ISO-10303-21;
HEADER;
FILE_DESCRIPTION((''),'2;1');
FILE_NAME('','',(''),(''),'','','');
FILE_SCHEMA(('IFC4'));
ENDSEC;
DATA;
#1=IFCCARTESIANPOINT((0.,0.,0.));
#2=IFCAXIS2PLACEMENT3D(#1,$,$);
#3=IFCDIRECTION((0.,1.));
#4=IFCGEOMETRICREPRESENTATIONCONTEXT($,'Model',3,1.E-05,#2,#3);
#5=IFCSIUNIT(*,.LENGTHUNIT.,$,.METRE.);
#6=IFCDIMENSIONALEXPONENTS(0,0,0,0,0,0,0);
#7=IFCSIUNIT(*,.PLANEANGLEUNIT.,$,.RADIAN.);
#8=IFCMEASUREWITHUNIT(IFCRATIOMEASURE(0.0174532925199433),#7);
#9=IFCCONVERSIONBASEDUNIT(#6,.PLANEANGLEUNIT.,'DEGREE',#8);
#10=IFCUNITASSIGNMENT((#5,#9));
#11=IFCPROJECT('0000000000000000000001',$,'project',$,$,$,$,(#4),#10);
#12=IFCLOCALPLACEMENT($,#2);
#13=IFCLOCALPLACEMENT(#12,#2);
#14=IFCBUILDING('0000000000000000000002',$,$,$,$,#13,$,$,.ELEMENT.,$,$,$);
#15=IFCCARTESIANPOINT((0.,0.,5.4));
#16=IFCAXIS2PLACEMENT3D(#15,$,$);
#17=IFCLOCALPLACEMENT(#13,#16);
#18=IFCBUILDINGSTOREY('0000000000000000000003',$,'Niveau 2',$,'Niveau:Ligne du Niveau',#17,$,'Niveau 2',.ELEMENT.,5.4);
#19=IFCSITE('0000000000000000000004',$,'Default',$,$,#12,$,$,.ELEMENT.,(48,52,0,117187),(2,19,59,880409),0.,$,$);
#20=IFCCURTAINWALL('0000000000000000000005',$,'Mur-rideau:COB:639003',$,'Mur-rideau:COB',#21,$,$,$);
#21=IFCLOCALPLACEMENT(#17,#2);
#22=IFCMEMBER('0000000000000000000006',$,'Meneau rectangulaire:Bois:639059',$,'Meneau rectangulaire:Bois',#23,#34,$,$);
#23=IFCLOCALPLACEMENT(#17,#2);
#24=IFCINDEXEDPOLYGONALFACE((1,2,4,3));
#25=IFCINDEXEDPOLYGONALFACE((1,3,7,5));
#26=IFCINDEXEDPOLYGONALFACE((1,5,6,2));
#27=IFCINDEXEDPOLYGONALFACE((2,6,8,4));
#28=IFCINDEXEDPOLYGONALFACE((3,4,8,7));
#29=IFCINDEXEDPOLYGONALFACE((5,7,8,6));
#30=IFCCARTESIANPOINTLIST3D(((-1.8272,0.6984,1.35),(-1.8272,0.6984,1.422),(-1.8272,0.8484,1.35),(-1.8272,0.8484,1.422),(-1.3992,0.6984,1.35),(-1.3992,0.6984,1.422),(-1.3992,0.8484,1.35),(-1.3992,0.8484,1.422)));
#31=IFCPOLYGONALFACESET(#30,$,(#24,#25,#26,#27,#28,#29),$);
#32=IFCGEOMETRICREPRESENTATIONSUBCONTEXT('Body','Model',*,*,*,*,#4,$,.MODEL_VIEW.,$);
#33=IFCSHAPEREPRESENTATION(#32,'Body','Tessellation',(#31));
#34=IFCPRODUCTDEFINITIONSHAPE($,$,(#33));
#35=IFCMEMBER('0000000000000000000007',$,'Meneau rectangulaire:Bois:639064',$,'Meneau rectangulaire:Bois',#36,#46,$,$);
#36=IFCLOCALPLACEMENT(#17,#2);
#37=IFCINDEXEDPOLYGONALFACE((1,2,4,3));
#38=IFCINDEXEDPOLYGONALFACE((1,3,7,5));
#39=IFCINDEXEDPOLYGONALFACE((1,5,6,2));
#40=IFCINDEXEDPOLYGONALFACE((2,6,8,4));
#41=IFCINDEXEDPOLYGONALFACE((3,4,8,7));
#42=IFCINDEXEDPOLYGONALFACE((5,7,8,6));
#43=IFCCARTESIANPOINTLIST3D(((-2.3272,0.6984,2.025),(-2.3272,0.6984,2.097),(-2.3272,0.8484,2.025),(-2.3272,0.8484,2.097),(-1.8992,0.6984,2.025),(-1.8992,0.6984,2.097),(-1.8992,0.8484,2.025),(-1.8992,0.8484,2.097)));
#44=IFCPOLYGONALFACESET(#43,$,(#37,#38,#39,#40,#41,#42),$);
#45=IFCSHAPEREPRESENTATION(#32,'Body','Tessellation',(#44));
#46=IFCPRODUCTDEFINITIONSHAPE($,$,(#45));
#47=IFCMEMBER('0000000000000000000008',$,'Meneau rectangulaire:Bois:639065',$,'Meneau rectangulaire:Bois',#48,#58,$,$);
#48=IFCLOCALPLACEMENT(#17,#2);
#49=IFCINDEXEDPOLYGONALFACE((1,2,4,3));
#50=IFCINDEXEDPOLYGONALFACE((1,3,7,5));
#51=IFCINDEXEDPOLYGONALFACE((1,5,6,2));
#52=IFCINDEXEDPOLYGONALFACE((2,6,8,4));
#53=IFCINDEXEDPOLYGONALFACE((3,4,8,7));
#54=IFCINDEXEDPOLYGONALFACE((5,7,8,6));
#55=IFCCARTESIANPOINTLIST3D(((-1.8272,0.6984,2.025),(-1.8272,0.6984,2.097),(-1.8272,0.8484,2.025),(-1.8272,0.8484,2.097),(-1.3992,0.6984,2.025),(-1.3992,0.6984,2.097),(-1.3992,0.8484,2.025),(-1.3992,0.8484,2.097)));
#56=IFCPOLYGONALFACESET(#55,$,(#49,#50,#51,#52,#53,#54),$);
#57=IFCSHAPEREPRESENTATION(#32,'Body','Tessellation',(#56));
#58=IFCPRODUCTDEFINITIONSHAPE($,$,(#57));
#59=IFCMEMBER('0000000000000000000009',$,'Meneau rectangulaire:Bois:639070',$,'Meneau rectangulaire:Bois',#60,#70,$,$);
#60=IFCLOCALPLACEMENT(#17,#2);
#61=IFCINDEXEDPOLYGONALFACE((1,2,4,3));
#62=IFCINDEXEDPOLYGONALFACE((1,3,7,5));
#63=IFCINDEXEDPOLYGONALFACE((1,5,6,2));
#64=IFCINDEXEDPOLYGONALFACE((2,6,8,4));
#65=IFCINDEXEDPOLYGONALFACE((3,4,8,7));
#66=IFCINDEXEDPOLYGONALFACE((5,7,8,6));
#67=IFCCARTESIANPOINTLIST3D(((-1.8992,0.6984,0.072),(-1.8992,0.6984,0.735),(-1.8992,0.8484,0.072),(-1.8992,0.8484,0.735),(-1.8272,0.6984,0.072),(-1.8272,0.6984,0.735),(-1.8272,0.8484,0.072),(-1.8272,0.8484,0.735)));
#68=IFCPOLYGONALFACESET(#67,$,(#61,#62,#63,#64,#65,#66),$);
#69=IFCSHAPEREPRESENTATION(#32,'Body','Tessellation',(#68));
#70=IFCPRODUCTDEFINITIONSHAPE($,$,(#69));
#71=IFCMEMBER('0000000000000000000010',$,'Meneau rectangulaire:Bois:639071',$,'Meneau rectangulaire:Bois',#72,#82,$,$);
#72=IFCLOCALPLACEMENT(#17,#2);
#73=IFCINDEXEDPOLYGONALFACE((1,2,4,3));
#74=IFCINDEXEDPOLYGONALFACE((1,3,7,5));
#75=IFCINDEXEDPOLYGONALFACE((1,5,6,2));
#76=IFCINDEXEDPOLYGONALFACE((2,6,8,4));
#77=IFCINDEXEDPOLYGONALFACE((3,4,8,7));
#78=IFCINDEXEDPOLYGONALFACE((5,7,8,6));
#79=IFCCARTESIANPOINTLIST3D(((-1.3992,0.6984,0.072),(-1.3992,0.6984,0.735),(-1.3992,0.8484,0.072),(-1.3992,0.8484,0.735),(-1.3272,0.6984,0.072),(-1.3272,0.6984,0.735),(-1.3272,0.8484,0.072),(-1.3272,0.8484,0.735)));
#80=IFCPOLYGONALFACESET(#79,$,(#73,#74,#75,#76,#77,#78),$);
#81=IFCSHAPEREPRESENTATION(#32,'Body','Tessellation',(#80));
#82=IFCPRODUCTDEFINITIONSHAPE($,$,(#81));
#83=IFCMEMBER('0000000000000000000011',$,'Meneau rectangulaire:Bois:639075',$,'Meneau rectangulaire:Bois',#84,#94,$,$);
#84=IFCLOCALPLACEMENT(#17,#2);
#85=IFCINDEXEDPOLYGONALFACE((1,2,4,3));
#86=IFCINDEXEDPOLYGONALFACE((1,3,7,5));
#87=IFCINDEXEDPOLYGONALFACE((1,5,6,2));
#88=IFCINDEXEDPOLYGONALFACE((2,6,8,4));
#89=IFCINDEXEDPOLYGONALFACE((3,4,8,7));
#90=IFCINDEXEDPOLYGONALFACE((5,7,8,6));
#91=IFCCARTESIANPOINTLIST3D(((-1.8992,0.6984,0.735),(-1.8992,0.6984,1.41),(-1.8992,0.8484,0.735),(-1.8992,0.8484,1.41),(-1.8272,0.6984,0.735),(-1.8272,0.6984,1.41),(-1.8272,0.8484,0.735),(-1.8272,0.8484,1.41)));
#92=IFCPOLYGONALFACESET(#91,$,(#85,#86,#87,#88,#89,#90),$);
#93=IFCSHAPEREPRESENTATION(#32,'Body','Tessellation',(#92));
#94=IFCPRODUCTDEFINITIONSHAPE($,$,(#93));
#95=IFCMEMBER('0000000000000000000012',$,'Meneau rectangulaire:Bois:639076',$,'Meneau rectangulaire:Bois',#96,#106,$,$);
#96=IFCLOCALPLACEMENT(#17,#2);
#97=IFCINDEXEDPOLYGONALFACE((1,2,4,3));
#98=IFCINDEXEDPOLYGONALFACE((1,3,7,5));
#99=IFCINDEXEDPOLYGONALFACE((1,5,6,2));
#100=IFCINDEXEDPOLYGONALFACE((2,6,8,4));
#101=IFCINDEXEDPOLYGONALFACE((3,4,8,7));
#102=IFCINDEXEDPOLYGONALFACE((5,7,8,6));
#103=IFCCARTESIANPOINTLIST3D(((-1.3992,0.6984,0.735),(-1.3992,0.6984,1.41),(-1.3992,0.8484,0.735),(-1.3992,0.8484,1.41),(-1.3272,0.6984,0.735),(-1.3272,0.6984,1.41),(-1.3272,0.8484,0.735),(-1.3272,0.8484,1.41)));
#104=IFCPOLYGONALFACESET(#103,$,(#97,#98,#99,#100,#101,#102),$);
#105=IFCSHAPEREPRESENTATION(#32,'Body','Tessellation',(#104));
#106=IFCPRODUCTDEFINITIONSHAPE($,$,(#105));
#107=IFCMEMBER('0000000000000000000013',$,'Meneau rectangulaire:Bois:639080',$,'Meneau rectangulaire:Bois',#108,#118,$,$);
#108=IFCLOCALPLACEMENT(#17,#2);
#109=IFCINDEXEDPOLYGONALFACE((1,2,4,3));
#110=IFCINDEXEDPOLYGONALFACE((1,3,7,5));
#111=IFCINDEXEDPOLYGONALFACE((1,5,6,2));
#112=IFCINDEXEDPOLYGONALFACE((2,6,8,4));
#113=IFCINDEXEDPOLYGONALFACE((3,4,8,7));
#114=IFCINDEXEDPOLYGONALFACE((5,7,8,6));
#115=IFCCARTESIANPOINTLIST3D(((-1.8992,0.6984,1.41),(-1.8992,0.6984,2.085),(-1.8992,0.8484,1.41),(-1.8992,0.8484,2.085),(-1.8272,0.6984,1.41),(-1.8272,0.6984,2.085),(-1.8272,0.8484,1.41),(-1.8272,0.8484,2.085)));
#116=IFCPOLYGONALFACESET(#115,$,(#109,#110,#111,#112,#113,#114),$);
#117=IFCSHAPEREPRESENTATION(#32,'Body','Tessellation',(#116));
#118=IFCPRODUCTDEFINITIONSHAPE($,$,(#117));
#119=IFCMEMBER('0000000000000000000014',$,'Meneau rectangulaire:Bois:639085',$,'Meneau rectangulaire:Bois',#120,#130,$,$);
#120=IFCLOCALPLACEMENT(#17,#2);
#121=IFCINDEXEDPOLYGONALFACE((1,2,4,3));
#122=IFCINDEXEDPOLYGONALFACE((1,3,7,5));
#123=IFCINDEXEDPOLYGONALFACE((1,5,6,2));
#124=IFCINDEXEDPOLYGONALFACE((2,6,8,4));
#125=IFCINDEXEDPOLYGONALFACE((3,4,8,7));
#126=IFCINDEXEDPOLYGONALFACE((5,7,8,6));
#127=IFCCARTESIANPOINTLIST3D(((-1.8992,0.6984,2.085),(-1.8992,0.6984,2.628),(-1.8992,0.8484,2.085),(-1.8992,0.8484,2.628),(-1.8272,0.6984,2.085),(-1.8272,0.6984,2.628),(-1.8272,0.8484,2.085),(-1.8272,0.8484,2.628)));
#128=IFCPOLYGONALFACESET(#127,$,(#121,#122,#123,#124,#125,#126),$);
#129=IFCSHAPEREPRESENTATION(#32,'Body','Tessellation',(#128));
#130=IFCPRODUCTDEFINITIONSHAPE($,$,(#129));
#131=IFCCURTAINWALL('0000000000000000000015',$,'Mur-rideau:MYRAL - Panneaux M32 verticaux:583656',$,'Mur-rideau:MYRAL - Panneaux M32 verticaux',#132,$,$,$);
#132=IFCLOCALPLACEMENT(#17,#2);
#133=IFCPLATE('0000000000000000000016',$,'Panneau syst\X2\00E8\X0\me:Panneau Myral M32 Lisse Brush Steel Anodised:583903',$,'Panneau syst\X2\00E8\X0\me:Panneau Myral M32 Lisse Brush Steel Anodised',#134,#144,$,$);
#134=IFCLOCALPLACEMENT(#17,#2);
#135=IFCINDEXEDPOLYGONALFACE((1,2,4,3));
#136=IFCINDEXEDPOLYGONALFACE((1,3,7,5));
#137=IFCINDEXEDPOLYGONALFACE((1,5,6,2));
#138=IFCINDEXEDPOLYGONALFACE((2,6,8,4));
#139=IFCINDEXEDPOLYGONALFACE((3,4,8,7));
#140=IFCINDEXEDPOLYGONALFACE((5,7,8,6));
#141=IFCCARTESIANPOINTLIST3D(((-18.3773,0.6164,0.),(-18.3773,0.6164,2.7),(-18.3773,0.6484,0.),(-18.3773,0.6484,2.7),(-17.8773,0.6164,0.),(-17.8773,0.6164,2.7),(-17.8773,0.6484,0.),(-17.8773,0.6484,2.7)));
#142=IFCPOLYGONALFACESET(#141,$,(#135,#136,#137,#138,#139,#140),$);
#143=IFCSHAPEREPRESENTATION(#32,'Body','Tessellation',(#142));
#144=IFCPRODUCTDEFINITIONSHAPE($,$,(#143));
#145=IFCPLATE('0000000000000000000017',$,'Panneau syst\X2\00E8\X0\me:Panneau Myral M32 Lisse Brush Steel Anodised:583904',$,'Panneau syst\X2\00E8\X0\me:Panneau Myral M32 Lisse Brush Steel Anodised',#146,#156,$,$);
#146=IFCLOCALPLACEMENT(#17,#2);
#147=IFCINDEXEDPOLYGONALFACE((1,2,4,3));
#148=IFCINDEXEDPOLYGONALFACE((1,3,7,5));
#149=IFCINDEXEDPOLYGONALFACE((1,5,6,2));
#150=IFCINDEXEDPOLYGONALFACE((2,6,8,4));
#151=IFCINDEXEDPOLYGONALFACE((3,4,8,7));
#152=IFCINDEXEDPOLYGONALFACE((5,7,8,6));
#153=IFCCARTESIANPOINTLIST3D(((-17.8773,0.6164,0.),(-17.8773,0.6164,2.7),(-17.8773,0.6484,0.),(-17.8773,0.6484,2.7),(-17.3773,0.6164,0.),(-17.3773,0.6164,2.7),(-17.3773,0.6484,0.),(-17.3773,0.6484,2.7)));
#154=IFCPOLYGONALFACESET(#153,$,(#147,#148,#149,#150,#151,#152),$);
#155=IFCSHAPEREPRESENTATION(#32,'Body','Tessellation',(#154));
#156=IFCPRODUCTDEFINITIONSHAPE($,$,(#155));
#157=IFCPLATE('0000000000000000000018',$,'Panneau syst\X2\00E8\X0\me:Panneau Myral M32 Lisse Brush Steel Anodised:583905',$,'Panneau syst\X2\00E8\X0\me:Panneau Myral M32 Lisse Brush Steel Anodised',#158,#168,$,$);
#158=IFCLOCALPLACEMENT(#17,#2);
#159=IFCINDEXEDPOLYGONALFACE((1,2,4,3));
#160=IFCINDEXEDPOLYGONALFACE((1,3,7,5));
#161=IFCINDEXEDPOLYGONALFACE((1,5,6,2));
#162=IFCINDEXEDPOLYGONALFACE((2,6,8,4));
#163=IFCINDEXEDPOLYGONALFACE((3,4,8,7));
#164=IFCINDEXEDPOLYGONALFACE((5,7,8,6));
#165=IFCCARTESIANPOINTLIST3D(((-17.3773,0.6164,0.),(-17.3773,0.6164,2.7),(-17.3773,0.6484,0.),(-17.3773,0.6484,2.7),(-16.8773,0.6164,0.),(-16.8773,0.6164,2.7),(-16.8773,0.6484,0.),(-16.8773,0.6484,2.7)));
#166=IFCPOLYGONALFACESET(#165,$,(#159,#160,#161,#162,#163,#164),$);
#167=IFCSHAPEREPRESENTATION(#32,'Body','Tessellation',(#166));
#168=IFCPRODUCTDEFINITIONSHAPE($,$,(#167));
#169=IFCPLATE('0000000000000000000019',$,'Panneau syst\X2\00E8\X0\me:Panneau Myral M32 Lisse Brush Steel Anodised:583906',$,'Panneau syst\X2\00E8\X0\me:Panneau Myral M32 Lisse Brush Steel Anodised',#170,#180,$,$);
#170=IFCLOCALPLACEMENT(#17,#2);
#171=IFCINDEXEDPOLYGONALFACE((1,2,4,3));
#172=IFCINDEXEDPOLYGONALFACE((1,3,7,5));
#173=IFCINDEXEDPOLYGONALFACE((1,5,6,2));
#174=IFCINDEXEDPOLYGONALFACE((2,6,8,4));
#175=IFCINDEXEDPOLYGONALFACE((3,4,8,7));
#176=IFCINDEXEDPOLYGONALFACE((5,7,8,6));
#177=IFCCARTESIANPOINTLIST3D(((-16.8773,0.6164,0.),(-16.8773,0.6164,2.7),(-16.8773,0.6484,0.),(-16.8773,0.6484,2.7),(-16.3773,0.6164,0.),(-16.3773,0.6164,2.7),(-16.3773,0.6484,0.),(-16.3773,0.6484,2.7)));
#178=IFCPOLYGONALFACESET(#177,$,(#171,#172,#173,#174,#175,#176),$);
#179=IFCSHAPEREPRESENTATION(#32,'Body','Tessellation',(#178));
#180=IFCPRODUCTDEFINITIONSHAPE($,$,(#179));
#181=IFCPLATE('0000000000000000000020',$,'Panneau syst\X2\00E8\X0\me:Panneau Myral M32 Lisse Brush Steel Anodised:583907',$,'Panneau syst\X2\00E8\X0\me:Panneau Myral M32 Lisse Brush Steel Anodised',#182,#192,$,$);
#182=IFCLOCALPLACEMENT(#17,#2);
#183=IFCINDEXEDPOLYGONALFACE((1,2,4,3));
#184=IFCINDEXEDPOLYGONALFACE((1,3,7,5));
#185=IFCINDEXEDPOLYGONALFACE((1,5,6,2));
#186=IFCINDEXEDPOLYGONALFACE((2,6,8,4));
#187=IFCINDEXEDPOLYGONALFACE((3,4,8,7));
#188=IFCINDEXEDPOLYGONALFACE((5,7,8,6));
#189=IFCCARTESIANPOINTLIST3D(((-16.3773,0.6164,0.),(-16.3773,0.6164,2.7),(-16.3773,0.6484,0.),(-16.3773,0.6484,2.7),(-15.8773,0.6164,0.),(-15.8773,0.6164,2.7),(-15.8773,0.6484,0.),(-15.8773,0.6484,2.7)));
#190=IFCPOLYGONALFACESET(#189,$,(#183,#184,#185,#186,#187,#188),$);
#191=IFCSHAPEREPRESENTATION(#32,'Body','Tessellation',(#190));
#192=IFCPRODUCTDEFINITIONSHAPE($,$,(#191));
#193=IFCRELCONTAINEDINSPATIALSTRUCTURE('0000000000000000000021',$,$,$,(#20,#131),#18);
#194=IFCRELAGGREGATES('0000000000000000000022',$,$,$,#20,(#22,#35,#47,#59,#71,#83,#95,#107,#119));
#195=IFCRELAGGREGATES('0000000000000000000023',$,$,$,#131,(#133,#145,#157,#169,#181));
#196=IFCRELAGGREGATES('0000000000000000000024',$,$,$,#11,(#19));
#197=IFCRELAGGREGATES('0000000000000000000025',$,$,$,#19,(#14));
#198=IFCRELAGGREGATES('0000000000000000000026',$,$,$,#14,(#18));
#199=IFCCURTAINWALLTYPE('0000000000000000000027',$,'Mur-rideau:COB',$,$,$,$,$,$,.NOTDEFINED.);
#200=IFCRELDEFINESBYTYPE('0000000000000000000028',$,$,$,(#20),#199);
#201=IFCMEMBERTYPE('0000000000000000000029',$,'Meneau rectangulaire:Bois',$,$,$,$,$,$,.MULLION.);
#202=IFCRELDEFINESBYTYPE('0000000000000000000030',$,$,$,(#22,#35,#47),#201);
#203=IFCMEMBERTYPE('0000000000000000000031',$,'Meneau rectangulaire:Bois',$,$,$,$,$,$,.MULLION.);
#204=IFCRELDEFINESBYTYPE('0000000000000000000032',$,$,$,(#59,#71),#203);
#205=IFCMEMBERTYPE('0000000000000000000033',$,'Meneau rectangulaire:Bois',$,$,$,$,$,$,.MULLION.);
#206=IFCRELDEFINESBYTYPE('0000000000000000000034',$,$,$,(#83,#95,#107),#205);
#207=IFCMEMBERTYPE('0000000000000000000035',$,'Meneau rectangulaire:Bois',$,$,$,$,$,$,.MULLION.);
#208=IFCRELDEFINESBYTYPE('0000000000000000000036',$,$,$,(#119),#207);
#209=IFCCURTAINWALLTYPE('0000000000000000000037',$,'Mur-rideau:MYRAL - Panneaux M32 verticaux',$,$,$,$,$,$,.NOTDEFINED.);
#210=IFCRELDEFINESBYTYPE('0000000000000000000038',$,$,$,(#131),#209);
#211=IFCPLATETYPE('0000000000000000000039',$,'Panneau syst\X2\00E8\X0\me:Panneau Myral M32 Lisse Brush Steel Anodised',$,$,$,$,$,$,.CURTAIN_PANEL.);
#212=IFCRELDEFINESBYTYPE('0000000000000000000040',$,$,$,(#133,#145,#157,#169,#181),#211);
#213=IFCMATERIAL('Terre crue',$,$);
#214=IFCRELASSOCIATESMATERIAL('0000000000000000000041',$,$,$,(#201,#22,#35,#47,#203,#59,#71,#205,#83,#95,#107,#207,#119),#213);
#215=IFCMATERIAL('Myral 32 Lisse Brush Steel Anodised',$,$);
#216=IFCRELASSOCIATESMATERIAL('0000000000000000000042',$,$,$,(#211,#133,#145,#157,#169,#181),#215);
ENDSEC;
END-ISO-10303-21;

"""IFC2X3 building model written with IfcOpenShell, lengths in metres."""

from ifc_helpers import new_model, entity, si_unit, converted_unit, direction, frame, origin, origin_2d_with_axis, place, context, subcontext, project, spatial, rectangle, extrude, source, transform, mapped, material, type_object, type_shapes, element, aggregate, save


model = new_model("IFC2X3")

# Units and contexts
model_context = context("Model", 3, precision=1e-05, world=origin(), true_north=direction((0.0, 1.0)))
body_context = subcontext(model_context, "Body", "Model", "MODEL_VIEW")
ifc_project = project(units=[si_unit("LENGTHUNIT", "METRE"), converted_unit("PLANEANGLEUNIT", "DEGREE", entity("IfcRatioMeasure", 0.0174532925199433), si_unit("PLANEANGLEUNIT", "RADIAN"), dimensions=[0, 0, 0, 0, 0, 0, 0])], contexts=[model_context])

# Site, building, storey
site_placement = place(None, origin())
site = spatial("IfcSite", under=ifc_project, at=site_placement, Name="Default", CompositionType="ELEMENT", RefLatitude=(48, 52, 0, 117187), RefLongitude=(2, 19, 59, 880409), RefElevation=0.0)
building_placement = place(site_placement, origin())
building = spatial("IfcBuilding", under=site, at=building_placement, CompositionType="ELEMENT")
storey_placement = place(building_placement, frame((0.0, 0.0, 5.4)))
storey = spatial("IfcBuildingStorey", under=building, at=storey_placement, Name="Niveau 2", ObjectType="Niveau:Ligne du Niveau", LongName="Niveau 2", CompositionType="ELEMENT", Elevation=5.4)

# Curtain wall, members
curtain_wall_type_1 = type_object("IfcCurtainWallType", Name="Mur-rideau:COB", PredefinedType="NOTDEFINED")
curtain_wall_1_placement = place(storey_placement, frame((0.0, 0.0, -5.4)))
curtain_wall_1 = element("IfcCurtainWall", 1, at=curtain_wall_1_placement, inside=storey, type_object=curtain_wall_type_1, Name="Mur-rideau:COB:639003", ObjectType="Mur-rideau:COB")
ifc_material_1 = material(Name="Terre crue")
member_type_1 = type_object("IfcMemberType", Name="Meneau rectangulaire:Bois", PredefinedType="MULLION", material=ifc_material_1)
shared_shape_1 = source(origin(), body_context, "Body", "SweptSolid", [
    extrude(rectangle(XDim=0.15, YDim=0.072, at=origin_2d_with_axis()), frame((-0.024, 0.0, -0.428), z_axis=(0.0, 0.0, 1.0), x_axis=(0.0, -1.0, 0.0)), (0.0, 0.0, 1.0), 0.428),
])
type_shapes(member_type_1, [shared_shape_1])
member_1_placement = place(storey_placement, frame((-1.3992, 0.7734, 1.41), z_axis=(1.0, 0.0, 0.0), x_axis=(0.0, 0.0, 1.0)))
member_1 = element("IfcMember", 2, at=member_1_placement, type_object=member_type_1, material=ifc_material_1, Name="Meneau rectangulaire:Bois:639059", ObjectType="Meneau rectangulaire:Bois", context=body_context, shape_type="MappedRepresentation", body=[
    mapped(shared_shape_1, transform((0.0, 0.0, 0.0), scale=1.0)),
])
member_2_placement = place(storey_placement, frame((-1.8992, 0.7734, 2.085), z_axis=(1.0, 0.0, 0.0), x_axis=(0.0, 0.0, 1.0)))
member_2 = element("IfcMember", 3, at=member_2_placement, type_object=member_type_1, material=ifc_material_1, Name="Meneau rectangulaire:Bois:639064", ObjectType="Meneau rectangulaire:Bois", context=body_context, shape_type="MappedRepresentation", body=[
    mapped(shared_shape_1, transform((0.0, 0.0, 0.0), scale=1.0)),
])
member_3_placement = place(storey_placement, frame((-1.3992, 0.7734, 2.085), z_axis=(1.0, 0.0, 0.0), x_axis=(0.0, 0.0, 1.0)))
member_3 = element("IfcMember", 4, at=member_3_placement, type_object=member_type_1, material=ifc_material_1, Name="Meneau rectangulaire:Bois:639065", ObjectType="Meneau rectangulaire:Bois", context=body_context, shape_type="MappedRepresentation", body=[
    mapped(shared_shape_1, transform((0.0, 0.0, 0.0), scale=1.0)),
])
member_type_2 = type_object("IfcMemberType", Name="Meneau rectangulaire:Bois", PredefinedType="MULLION", material=ifc_material_1)
shared_shape_2 = source(origin(), body_context, "Body", "SweptSolid", [
    extrude(rectangle(XDim=0.15, YDim=0.072, at=origin_2d_with_axis()), frame((-0.024, 0.0, -0.663), z_axis=(0.0, 0.0, 1.0), x_axis=(0.0, -1.0, 0.0)), (0.0, 0.0, 1.0), 0.663),
])
type_shapes(member_type_2, [shared_shape_2])
member_4_placement = place(storey_placement, frame((-1.8392, 0.7734, 0.072), z_axis=(0.0, 0.0, -1.0), x_axis=(1.0, 0.0, 0.0)))
member_4 = element("IfcMember", 5, at=member_4_placement, type_object=member_type_2, material=ifc_material_1, Name="Meneau rectangulaire:Bois:639070", ObjectType="Meneau rectangulaire:Bois", context=body_context, shape_type="MappedRepresentation", body=[
    mapped(shared_shape_2, transform((0.0, 0.0, 0.0), scale=1.0)),
])
member_5_placement = place(storey_placement, frame((-1.3392, 0.7734, 0.072), z_axis=(0.0, 0.0, -1.0), x_axis=(1.0, 0.0, 0.0)))
member_5 = element("IfcMember", 6, at=member_5_placement, type_object=member_type_2, material=ifc_material_1, Name="Meneau rectangulaire:Bois:639071", ObjectType="Meneau rectangulaire:Bois", context=body_context, shape_type="MappedRepresentation", body=[
    mapped(shared_shape_2, transform((0.0, 0.0, 0.0), scale=1.0)),
])
member_type_3 = type_object("IfcMemberType", Name="Meneau rectangulaire:Bois", PredefinedType="MULLION", material=ifc_material_1)
shared_shape_3 = source(origin(), body_context, "Body", "SweptSolid", [
    extrude(rectangle(XDim=0.15, YDim=0.072, at=origin_2d_with_axis()), frame((-0.024, 0.0, -0.675), z_axis=(0.0, 0.0, 1.0), x_axis=(0.0, -1.0, 0.0)), (0.0, 0.0, 1.0), 0.675),
])
type_shapes(member_type_3, [shared_shape_3])
member_6_placement = place(storey_placement, frame((-1.8392, 0.7734, 0.735), z_axis=(0.0, 0.0, -1.0), x_axis=(1.0, 0.0, 0.0)))
member_6 = element("IfcMember", 7, at=member_6_placement, type_object=member_type_3, material=ifc_material_1, Name="Meneau rectangulaire:Bois:639075", ObjectType="Meneau rectangulaire:Bois", context=body_context, shape_type="MappedRepresentation", body=[
    mapped(shared_shape_3, transform((0.0, 0.0, 0.0), scale=1.0)),
])
member_7_placement = place(storey_placement, frame((-1.3392, 0.7734, 0.735), z_axis=(0.0, 0.0, -1.0), x_axis=(1.0, 0.0, 0.0)))
member_7 = element("IfcMember", 8, at=member_7_placement, type_object=member_type_3, material=ifc_material_1, Name="Meneau rectangulaire:Bois:639076", ObjectType="Meneau rectangulaire:Bois", context=body_context, shape_type="MappedRepresentation", body=[
    mapped(shared_shape_3, transform((0.0, 0.0, 0.0), scale=1.0)),
])
member_8_placement = place(storey_placement, frame((-1.8392, 0.7734, 1.41), z_axis=(0.0, 0.0, -1.0), x_axis=(1.0, 0.0, 0.0)))
member_8 = element("IfcMember", 9, at=member_8_placement, type_object=member_type_3, material=ifc_material_1, Name="Meneau rectangulaire:Bois:639080", ObjectType="Meneau rectangulaire:Bois", context=body_context, shape_type="MappedRepresentation", body=[
    mapped(shared_shape_3, transform((0.0, 0.0, 0.0), scale=1.0)),
])
member_type_4 = type_object("IfcMemberType", Name="Meneau rectangulaire:Bois", PredefinedType="MULLION", material=ifc_material_1)
shared_shape_4 = source(origin(), body_context, "Body", "SweptSolid", [
    extrude(rectangle(XDim=0.15, YDim=0.072, at=origin_2d_with_axis()), frame((-0.024, 0.0, -0.543), z_axis=(0.0, 0.0, 1.0), x_axis=(0.0, -1.0, 0.0)), (0.0, 0.0, 1.0), 0.543),
])
type_shapes(member_type_4, [shared_shape_4])
member_9_placement = place(storey_placement, frame((-1.8392, 0.7734, 2.085), z_axis=(0.0, 0.0, -1.0), x_axis=(1.0, 0.0, 0.0)))
member_9 = element("IfcMember", 10, at=member_9_placement, type_object=member_type_4, material=ifc_material_1, Name="Meneau rectangulaire:Bois:639085", ObjectType="Meneau rectangulaire:Bois", context=body_context, shape_type="MappedRepresentation", body=[
    mapped(shared_shape_4, transform((0.0, 0.0, 0.0), scale=1.0)),
])
aggregate(curtain_wall_1, [member_1, member_2, member_3, member_4, member_5, member_6, member_7, member_8, member_9])

# Curtain wall, plates
curtain_wall_type_2 = type_object("IfcCurtainWallType", Name="Mur-rideau:MYRAL - Panneaux M32 verticaux", PredefinedType="NOTDEFINED")
curtain_wall_2_placement = place(storey_placement, frame((0.0, 0.0, -5.4)))
curtain_wall_2 = element("IfcCurtainWall", 11, at=curtain_wall_2_placement, inside=storey, type_object=curtain_wall_type_2, Name="Mur-rideau:MYRAL - Panneaux M32 verticaux:583656", ObjectType="Mur-rideau:MYRAL - Panneaux M32 verticaux")
ifc_material_2 = material(Name="Myral 32 Lisse Brush Steel Anodised")
plate_type = type_object("IfcPlateType", Name="Panneau système:Panneau Myral M32 Lisse Brush Steel Anodised", PredefinedType="CURTAIN_PANEL", material=ifc_material_2)
shared_shape_5 = source(origin(), body_context, "Body", "SweptSolid", [
    extrude(rectangle(XDim=0.032, YDim=0.5, at=origin_2d_with_axis()), frame((0.0, -0.016, 0.0), z_axis=(0.0, 0.0, 1.0), x_axis=(0.0, 1.0, 0.0)), (0.0, 0.0, 1.0), 2.7),
])
type_shapes(plate_type, [shared_shape_5])
plate_1_placement = place(curtain_wall_2_placement, frame((-18.1273, 0.6484, 5.4)))
plate_1 = element("IfcPlate", 12, at=plate_1_placement, type_object=plate_type, material=ifc_material_2, Name="Panneau système:Panneau Myral M32 Lisse Brush Steel Anodised:583903", ObjectType="Panneau système:Panneau Myral M32 Lisse Brush Steel Anodised", context=body_context, shape_type="MappedRepresentation", body=[
    mapped(shared_shape_5, transform((0.0, 0.0, 0.0), scale=1.0)),
])
plate_2_placement = place(curtain_wall_2_placement, frame((-17.6273, 0.6484, 5.4)))
plate_2 = element("IfcPlate", 13, at=plate_2_placement, type_object=plate_type, material=ifc_material_2, Name="Panneau système:Panneau Myral M32 Lisse Brush Steel Anodised:583904", ObjectType="Panneau système:Panneau Myral M32 Lisse Brush Steel Anodised", context=body_context, shape_type="MappedRepresentation", body=[
    mapped(shared_shape_5, transform((0.0, 0.0, 0.0), scale=1.0)),
])
plate_3_placement = place(curtain_wall_2_placement, frame((-17.1273, 0.6484, 5.4)))
plate_3 = element("IfcPlate", 14, at=plate_3_placement, type_object=plate_type, material=ifc_material_2, Name="Panneau système:Panneau Myral M32 Lisse Brush Steel Anodised:583905", ObjectType="Panneau système:Panneau Myral M32 Lisse Brush Steel Anodised", context=body_context, shape_type="MappedRepresentation", body=[
    mapped(shared_shape_5, transform((0.0, 0.0, 0.0), scale=1.0)),
])
plate_4_placement = place(curtain_wall_2_placement, frame((-16.6273, 0.6484, 5.4)))
plate_4 = element("IfcPlate", 15, at=plate_4_placement, type_object=plate_type, material=ifc_material_2, Name="Panneau système:Panneau Myral M32 Lisse Brush Steel Anodised:583906", ObjectType="Panneau système:Panneau Myral M32 Lisse Brush Steel Anodised", context=body_context, shape_type="MappedRepresentation", body=[
    mapped(shared_shape_5, transform((0.0, 0.0, 0.0), scale=1.0)),
])
plate_5_placement = place(curtain_wall_2_placement, frame((-16.1273, 0.6484, 5.4)))
plate_5 = element("IfcPlate", 16, at=plate_5_placement, type_object=plate_type, material=ifc_material_2, Name="Panneau système:Panneau Myral M32 Lisse Brush Steel Anodised:583907", ObjectType="Panneau système:Panneau Myral M32 Lisse Brush Steel Anodised", context=body_context, shape_type="MappedRepresentation", body=[
    mapped(shared_shape_5, transform((0.0, 0.0, 0.0), scale=1.0)),
])
aggregate(curtain_wall_2, [plate_1, plate_2, plate_3, plate_4, plate_5])

save(model, "model.ifc")
